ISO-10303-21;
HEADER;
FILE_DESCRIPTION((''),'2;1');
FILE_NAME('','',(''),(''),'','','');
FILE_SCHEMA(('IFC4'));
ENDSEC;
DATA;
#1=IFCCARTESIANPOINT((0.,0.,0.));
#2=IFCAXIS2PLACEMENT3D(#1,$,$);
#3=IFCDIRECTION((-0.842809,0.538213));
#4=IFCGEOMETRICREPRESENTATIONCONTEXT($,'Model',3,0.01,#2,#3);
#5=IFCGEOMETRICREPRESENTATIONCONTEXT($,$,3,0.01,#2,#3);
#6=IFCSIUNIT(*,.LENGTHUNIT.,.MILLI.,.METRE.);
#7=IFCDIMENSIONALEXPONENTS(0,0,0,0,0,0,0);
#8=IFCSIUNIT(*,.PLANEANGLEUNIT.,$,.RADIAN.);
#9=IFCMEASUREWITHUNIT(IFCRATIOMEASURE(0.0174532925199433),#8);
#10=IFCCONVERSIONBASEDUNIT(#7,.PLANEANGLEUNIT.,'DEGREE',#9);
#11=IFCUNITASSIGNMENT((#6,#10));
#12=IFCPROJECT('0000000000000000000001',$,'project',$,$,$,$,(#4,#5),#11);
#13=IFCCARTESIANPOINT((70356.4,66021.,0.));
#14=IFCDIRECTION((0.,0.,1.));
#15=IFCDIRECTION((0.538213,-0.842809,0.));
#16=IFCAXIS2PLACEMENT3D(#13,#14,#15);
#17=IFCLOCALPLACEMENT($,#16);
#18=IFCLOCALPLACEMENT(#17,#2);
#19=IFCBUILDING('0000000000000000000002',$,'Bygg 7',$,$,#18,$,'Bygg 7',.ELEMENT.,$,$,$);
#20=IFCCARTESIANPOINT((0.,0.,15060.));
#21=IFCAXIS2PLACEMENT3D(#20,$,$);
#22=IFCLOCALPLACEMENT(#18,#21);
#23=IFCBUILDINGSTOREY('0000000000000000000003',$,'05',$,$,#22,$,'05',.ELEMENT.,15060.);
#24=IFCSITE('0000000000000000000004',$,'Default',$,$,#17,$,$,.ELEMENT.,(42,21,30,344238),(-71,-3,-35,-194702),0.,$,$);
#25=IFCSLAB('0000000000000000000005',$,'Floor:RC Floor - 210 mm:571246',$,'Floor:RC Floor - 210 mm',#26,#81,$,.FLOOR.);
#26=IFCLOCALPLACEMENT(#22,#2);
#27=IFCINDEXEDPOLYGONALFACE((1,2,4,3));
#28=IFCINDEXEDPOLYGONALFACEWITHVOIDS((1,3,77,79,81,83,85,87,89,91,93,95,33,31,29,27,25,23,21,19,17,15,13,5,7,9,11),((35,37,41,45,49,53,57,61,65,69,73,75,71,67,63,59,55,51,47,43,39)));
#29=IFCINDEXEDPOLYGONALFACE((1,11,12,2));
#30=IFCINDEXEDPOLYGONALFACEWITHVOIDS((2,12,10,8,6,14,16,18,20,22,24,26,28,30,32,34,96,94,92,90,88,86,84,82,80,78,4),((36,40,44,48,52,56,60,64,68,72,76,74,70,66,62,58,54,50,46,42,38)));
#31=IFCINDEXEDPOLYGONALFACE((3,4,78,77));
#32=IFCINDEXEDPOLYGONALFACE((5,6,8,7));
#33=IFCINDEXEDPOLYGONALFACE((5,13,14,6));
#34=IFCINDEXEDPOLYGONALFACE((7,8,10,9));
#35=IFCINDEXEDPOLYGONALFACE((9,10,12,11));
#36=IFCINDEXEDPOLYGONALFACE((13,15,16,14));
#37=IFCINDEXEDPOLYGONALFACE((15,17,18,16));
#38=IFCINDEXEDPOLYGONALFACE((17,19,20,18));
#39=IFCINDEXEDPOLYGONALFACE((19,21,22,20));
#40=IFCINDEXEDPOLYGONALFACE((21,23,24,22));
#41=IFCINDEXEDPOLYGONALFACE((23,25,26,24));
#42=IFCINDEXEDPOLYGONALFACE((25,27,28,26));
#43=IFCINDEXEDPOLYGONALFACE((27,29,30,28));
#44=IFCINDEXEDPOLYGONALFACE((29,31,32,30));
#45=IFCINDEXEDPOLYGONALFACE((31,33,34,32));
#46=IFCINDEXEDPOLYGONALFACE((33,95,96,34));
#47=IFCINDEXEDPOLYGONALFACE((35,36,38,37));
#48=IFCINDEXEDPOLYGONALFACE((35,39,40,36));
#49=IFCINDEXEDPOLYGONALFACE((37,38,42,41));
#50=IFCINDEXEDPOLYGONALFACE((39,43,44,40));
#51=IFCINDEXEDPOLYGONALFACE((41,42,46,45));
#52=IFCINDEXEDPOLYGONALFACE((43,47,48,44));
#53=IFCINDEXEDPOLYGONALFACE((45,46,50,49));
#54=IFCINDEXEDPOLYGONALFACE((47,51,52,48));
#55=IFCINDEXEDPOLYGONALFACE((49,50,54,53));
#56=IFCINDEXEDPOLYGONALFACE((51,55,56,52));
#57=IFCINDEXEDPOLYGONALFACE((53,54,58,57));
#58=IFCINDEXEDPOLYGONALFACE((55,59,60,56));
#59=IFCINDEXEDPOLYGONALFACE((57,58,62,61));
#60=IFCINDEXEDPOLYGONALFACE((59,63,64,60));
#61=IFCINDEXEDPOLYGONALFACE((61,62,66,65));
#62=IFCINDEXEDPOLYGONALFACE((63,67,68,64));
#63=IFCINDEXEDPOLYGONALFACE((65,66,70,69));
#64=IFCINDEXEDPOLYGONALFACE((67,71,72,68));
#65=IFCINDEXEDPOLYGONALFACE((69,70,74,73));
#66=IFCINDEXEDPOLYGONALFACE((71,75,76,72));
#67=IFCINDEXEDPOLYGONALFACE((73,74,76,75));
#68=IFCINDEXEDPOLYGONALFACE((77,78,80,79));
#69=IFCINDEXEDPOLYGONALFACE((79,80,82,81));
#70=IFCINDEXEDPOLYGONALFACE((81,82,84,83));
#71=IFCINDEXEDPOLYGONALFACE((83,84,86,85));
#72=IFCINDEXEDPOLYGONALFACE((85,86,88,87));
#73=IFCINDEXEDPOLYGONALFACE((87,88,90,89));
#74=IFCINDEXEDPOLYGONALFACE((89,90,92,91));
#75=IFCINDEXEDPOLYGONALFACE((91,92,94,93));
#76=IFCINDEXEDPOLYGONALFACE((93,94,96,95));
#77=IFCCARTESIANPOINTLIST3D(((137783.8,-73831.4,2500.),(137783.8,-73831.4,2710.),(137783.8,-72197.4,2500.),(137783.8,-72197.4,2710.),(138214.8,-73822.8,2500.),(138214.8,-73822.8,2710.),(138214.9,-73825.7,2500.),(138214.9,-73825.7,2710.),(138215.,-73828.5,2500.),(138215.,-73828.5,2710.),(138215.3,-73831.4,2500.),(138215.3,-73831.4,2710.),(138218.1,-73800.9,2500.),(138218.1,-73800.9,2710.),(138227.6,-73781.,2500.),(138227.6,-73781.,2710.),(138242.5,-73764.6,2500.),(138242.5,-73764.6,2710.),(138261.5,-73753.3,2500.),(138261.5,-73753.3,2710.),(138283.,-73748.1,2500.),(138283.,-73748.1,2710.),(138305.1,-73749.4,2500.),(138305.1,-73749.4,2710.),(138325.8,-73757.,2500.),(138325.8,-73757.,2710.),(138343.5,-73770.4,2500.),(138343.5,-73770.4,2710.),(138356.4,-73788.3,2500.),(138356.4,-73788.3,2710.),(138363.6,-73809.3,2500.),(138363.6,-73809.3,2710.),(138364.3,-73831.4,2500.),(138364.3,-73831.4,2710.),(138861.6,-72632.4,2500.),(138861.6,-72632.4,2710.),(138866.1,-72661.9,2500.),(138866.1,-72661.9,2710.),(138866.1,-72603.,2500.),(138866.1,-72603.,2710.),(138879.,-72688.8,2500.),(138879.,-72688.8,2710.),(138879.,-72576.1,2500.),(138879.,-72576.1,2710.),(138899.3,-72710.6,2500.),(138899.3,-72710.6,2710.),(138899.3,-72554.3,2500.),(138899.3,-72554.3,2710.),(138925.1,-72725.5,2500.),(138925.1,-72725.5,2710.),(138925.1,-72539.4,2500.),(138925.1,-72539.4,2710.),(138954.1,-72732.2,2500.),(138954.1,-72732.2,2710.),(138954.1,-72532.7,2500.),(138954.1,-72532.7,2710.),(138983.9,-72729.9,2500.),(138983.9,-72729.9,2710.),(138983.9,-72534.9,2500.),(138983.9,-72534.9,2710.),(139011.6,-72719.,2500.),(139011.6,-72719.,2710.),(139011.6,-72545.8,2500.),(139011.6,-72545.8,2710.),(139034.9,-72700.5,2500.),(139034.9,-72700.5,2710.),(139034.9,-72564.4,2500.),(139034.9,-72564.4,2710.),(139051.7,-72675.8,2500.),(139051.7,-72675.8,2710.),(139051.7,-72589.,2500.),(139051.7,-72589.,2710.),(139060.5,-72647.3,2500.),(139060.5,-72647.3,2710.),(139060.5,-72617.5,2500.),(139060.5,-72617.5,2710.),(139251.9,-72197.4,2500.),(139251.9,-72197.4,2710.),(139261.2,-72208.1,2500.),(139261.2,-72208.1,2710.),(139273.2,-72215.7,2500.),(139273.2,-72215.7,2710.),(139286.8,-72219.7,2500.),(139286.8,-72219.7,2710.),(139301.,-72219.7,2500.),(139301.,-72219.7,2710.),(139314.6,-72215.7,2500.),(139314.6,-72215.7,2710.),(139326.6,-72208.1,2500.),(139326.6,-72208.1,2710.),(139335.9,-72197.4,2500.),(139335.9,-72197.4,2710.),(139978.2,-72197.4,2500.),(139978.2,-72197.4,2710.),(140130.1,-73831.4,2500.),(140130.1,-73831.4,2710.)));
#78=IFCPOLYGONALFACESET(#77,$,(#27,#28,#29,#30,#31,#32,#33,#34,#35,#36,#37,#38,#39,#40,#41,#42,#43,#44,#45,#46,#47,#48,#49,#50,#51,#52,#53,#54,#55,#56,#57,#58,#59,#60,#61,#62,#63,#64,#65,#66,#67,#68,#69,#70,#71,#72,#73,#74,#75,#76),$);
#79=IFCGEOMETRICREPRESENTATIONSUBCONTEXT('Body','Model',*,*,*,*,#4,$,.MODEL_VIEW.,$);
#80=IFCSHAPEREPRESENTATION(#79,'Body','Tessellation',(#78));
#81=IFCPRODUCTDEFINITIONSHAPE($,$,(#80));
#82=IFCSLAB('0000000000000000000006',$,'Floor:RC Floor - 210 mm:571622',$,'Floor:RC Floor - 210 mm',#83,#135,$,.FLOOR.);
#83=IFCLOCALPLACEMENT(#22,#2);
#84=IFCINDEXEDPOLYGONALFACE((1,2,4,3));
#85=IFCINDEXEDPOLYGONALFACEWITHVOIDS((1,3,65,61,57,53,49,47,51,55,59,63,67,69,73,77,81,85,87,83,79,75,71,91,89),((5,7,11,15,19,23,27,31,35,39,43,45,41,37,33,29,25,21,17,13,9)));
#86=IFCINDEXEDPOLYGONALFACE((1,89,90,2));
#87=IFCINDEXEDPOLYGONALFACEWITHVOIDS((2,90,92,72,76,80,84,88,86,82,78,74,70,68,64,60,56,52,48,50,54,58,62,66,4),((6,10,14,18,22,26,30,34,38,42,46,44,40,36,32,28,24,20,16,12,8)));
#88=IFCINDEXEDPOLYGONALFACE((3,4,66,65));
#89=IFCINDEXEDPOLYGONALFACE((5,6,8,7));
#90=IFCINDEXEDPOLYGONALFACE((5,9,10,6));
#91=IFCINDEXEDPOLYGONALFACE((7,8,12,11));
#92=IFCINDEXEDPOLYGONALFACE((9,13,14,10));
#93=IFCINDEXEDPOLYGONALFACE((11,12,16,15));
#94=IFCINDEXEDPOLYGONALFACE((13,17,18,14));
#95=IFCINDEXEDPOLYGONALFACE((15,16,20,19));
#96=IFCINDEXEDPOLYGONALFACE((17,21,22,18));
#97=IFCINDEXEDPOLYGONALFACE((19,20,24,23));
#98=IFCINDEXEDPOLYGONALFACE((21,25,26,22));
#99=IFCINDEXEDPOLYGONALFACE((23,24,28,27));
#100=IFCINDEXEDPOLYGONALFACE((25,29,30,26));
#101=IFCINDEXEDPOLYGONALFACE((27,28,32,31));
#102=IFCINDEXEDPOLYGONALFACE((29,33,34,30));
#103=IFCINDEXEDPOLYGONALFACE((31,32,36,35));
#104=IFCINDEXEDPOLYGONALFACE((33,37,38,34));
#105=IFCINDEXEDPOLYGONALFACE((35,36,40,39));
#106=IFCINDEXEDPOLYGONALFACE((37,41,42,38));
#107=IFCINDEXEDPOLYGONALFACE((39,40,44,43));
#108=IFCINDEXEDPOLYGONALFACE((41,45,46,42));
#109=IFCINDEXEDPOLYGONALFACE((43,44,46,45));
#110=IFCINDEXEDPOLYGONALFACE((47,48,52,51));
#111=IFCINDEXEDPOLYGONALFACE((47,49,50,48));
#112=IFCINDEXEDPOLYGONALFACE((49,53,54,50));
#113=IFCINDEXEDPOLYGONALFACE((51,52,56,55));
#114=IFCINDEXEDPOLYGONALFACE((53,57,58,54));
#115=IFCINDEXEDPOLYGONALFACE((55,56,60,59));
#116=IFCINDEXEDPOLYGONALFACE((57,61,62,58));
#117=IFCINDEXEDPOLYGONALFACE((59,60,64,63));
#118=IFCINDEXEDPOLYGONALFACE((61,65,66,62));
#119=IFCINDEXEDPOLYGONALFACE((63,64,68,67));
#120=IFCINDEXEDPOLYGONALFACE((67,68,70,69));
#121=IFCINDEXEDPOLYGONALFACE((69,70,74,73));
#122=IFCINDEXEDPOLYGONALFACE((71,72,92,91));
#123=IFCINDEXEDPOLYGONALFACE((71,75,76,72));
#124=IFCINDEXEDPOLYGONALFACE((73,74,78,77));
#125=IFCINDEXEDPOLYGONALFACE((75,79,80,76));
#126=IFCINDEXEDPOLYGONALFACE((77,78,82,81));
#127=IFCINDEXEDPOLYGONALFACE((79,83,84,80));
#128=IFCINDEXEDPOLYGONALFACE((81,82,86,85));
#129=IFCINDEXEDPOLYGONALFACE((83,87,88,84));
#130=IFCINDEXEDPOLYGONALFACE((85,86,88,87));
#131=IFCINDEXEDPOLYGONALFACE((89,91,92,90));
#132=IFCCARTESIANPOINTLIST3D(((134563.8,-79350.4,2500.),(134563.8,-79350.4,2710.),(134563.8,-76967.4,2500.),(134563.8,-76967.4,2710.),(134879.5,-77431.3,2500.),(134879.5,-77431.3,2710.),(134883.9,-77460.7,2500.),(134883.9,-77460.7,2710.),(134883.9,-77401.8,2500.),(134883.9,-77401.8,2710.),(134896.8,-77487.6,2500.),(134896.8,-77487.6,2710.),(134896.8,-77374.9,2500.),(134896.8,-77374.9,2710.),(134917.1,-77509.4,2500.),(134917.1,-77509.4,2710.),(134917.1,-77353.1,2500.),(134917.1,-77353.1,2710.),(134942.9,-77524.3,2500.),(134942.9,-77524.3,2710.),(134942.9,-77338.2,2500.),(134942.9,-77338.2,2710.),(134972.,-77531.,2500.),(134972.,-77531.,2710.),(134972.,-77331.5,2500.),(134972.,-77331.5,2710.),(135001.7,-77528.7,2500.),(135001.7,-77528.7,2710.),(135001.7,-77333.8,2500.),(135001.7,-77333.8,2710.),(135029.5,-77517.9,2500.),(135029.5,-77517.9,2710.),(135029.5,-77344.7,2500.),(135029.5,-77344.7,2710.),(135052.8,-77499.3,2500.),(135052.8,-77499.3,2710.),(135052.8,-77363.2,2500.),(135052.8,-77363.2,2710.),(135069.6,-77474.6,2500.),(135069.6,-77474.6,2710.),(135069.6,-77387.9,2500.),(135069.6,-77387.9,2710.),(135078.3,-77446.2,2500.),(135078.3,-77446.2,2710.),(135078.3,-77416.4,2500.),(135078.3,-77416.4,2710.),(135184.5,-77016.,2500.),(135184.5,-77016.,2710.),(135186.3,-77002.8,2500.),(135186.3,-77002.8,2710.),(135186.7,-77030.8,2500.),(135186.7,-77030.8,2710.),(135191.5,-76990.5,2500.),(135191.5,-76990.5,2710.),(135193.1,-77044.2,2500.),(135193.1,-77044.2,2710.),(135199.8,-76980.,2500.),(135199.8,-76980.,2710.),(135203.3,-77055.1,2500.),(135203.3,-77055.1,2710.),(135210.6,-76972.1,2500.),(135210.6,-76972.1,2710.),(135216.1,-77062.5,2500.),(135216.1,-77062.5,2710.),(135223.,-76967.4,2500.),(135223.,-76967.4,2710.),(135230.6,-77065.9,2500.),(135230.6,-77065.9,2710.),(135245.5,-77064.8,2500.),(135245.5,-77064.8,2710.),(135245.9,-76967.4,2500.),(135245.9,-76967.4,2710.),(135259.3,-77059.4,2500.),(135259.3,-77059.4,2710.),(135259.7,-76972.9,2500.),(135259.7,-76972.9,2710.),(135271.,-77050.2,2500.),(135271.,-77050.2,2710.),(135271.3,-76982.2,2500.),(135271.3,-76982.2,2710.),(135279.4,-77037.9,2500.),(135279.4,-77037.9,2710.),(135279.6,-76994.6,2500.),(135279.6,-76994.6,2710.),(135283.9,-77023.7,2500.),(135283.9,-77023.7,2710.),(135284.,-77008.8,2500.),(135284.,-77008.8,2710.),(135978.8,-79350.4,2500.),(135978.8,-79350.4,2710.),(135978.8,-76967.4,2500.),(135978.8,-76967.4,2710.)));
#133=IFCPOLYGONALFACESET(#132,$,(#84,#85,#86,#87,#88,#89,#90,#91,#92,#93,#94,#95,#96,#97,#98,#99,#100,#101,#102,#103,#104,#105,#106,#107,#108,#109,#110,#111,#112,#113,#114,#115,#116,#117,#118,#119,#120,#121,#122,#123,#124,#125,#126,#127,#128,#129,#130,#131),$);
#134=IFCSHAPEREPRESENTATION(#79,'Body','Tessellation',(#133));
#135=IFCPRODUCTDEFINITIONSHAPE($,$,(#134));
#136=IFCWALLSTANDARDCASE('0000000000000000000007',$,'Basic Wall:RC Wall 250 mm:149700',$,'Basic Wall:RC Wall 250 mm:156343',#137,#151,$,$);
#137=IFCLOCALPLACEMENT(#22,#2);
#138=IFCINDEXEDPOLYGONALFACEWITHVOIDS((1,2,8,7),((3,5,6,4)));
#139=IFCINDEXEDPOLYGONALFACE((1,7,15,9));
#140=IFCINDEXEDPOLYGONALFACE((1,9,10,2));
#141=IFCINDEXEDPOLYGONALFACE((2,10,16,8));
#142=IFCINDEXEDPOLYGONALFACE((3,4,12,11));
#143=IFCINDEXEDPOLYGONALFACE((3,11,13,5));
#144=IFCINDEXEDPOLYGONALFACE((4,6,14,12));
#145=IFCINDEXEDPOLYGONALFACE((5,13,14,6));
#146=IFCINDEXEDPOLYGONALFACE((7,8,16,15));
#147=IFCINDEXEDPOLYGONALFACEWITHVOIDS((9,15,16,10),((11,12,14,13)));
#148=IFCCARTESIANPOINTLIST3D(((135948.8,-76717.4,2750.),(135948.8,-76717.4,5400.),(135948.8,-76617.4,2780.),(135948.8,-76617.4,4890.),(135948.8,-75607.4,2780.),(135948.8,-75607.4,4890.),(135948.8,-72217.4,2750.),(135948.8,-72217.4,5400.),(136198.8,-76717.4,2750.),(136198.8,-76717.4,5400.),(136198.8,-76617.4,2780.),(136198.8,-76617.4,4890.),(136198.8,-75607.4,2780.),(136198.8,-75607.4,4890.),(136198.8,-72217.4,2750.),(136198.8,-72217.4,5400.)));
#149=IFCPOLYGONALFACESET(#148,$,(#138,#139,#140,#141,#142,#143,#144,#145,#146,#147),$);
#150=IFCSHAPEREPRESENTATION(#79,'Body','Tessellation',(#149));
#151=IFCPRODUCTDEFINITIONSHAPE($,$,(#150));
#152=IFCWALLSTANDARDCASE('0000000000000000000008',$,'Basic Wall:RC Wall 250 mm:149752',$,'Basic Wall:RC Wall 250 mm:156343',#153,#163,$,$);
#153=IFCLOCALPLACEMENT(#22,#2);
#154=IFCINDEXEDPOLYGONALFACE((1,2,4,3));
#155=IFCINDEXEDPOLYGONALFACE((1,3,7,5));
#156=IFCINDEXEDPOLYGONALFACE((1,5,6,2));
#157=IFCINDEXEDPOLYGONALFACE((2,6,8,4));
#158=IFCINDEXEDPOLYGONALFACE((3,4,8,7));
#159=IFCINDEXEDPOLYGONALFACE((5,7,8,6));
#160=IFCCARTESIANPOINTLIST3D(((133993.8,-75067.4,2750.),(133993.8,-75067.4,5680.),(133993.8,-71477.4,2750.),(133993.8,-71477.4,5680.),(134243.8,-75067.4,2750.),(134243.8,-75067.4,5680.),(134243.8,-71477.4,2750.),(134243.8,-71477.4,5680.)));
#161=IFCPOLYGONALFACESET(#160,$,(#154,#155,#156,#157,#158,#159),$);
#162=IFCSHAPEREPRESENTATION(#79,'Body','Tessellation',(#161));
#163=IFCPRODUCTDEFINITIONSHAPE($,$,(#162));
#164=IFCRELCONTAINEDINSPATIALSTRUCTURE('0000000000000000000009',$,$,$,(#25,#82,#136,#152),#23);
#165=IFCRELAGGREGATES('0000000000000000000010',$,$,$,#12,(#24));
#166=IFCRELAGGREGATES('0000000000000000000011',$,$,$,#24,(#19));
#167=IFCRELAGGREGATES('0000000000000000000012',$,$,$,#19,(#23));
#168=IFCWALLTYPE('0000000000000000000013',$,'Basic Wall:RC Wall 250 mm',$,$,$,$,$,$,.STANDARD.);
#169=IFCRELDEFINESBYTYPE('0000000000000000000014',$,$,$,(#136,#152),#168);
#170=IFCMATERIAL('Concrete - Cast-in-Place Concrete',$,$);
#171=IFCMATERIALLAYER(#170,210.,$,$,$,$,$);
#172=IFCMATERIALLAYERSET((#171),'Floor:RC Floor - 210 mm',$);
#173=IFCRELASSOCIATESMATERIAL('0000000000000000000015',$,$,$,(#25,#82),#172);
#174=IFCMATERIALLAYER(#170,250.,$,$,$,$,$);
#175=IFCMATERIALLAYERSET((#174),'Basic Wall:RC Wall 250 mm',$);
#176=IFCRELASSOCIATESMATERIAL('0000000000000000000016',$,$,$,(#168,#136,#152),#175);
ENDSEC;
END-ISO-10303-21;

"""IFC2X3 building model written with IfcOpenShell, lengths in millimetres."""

from ifc_helpers import new_model, entity, si_unit, converted_unit, direction, frame, frame_2d, origin, origin_2d_with_axis, place, context, subcontext, project, spatial, polyline, rectangle, circle, outline, extrude, clip, bounded_halfspace, material, layer, layer_set, layer_usage, type_object, element, save


model = new_model("IFC2X3")

# Units and contexts
model_context = context("Model", 3, precision=0.01, world=origin(), true_north=direction((-0.842809, 0.538213)))
context_of_model = context(None, 3, precision=0.01, world=origin(), true_north=direction((-0.842809, 0.538213)))
body_context = subcontext(model_context, "Body", "Model", "MODEL_VIEW")
ifc_project = project(units=[si_unit("LENGTHUNIT", "METRE", prefix="MILLI"), converted_unit("PLANEANGLEUNIT", "DEGREE", entity("IfcRatioMeasure", 0.0174532925199433), si_unit("PLANEANGLEUNIT", "RADIAN"), dimensions=[0, 0, 0, 0, 0, 0, 0])], contexts=[model_context, context_of_model])

# Site, building, storey
site_placement = place(None, frame((70356.4, 66021.0, 0.0), z_axis=(0.0, 0.0, 1.0), x_axis=(0.538213, -0.842809, 0.0)))
site = spatial("IfcSite", under=ifc_project, at=site_placement, Name="Default", CompositionType="ELEMENT", RefLatitude=(42, 21, 30, 344238), RefLongitude=(-71, -3, -35, -194702), RefElevation=0.0)
building_placement = place(site_placement, origin())
building = spatial("IfcBuilding", under=site, at=building_placement, Name="Bygg 7", LongName="Bygg 7", CompositionType="ELEMENT")
storey_placement = place(building_placement, frame((0.0, 0.0, 15060.0)))
storey = spatial("IfcBuildingStorey", under=building, at=storey_placement, Name="05", LongName="05", CompositionType="ELEMENT", Elevation=15060.0)

# Slabs, openings
ifc_material_1 = material(Name="Concrete - Cast-in-Place Concrete")
ifc_layer_1 = layer(ifc_material_1, 210.0)
ifc_layer_set_1 = layer_set([ifc_layer_1], Name="Floor:RC Floor - 210 mm")
ifc_layer_usage_1 = layer_usage(ifc_layer_set_1, "AXIS3", "POSITIVE", 0.0)
slab_1_placement = place(storey_placement, frame((137783.8, -73831.4, 2500.0)))
slab_1 = element("IfcSlab", 1, at=slab_1_placement, inside=storey, material=ifc_layer_usage_1, Name="Floor:RC Floor - 210 mm:571246", ObjectType="Floor:RC Floor - 210 mm", PredefinedType="FLOOR", context=body_context, shape_type="SweptSolid", body=[
    extrude(outline(polyline([(1173.1, 817.0), (-1021.3, 817.0), (-1173.1, -817.0), (1173.1, -817.0), (1173.1, 817.0)])), frame((1173.1, 817.0, 210.0), z_axis=(0.0, 0.0, -1.0), x_axis=(-1.0, 0.0, 0.0)), (0.0, 0.0, 1.0), 210.0),
])
opening_1_placement = place(storey_placement, frame((137783.8, -73831.4, 2500.0)))
element("IfcOpeningElement", 2, at=opening_1_placement, cuts=slab_1, ObjectType="Opening", context=body_context, shape_type="SweptSolid", body=[
    extrude(circle(Radius=100.0, at=frame_2d((-4.7, 381.9), x_axis=(1.0, 0.0))), frame((1173.1, 817.0, 210.0), z_axis=(0.0, 0.0, -1.0), x_axis=(-1.0, 0.0, 0.0)), (0.0, 0.0, 1.0), 210.0),
])
opening_2_placement = place(storey_placement, frame((137783.8, -73831.4, 2500.0)))
element("IfcOpeningElement", 3, at=opening_2_placement, cuts=slab_1, ObjectType="Opening", context=body_context, shape_type="SweptSolid", body=[
    extrude(circle(Radius=75.0, at=frame_2d((667.1, -808.4), x_axis=(1.0, 0.0))), frame((1173.1, 817.0, 210.0), z_axis=(0.0, 0.0, -1.0), x_axis=(-1.0, 0.0, 0.0)), (0.0, 0.0, 1.0), 210.0),
])
opening_3_placement = place(storey_placement, frame((137783.8, -73831.4, 2500.0)))
element("IfcOpeningElement", 4, at=opening_3_placement, cuts=slab_1, ObjectType="Opening", context=body_context, shape_type="SweptSolid", body=[
    extrude(circle(Radius=50.0, at=frame_2d((-336.9, 844.1), x_axis=(1.0, 0.0))), frame((1173.1, 817.0, 210.0), z_axis=(0.0, 0.0, -1.0), x_axis=(-1.0, 0.0, 0.0)), (0.0, 0.0, 1.0), 210.0),
])
ifc_layer_usage_2 = layer_usage(ifc_layer_set_1, "AXIS3", "POSITIVE", 0.0)
slab_2_placement = place(storey_placement, frame((134563.8, -79350.4, 2500.0)))
slab_2 = element("IfcSlab", 5, at=slab_2_placement, inside=storey, material=ifc_layer_usage_2, Name="Floor:RC Floor - 210 mm:571622", ObjectType="Floor:RC Floor - 210 mm", PredefinedType="FLOOR", context=body_context, shape_type="SweptSolid", body=[
    extrude(rectangle(XDim=2396.0, YDim=1415.0, at=frame_2d((0.0, -6.5), x_axis=(0.0, -1.0))), frame((707.5, 1191.5, 210.0), z_axis=(0.0, 0.0, -1.0), x_axis=(-1.0, 0.0, 0.0)), (0.0, 0.0, 1.0), 210.0),
])
opening_4_placement = place(storey_placement, frame((134563.8, -79350.4, 2500.0)))
element("IfcOpeningElement", 6, at=opening_4_placement, cuts=slab_2, ObjectType="Opening", context=body_context, shape_type="SweptSolid", body=[
    extrude(rectangle(XDim=1415.0, YDim=577.0, at=frame_2d((0.0, -1480.0), x_axis=(1.0, 0.0))), frame((707.5, 1191.5, 210.0), z_axis=(0.0, 0.0, -1.0), x_axis=(-1.0, 0.0, 0.0)), (0.0, 0.0, 1.0), 210.0),
])
opening_5_placement = place(storey_placement, frame((134563.8, -79350.4, 2500.0)))
element("IfcOpeningElement", 7, at=opening_5_placement, cuts=slab_2, ObjectType="Opening", context=body_context, shape_type="SweptSolid", body=[
    extrude(circle(Radius=100.0, at=frame_2d((291.9, 727.6), x_axis=(1.0, 0.0))), frame((707.5, 1191.5, 210.0), z_axis=(0.0, 0.0, -1.0), x_axis=(-1.0, 0.0, 0.0)), (0.0, 0.0, 1.0), 210.0),
])
opening_6_placement = place(storey_placement, frame((134563.8, -79350.4, 2500.0)))
element("IfcOpeningElement", 8, at=opening_6_placement, cuts=slab_2, ObjectType="Opening", context=body_context, shape_type="SweptSolid", body=[
    extrude(circle(Radius=50.0, at=frame_2d((36.9, 1142.8), x_axis=(1.0, 0.0))), frame((707.5, 1191.5, 210.0), z_axis=(0.0, 0.0, -1.0), x_axis=(-1.0, 0.0, 0.0)), (0.0, 0.0, 1.0), 210.0),
])

# Wall, opening
ifc_layer_2 = layer(ifc_material_1, 250.0)
ifc_layer_set_2 = layer_set([ifc_layer_2], Name="Basic Wall:RC Wall 250 mm")
ifc_layer_usage_3 = layer_usage(ifc_layer_set_2, "AXIS2", "NEGATIVE", 125.0)
wall_type_1 = type_object("IfcWallType", Name="Basic Wall:RC Wall 250 mm", PredefinedType="STANDARD", material=ifc_layer_set_2)
wall_1_placement = place(storey_placement, frame((136073.8, -76717.4, 2750.0), z_axis=(0.0, 0.0, 1.0), x_axis=(0.0, 1.0, 0.0)))
wall_1 = element("IfcWallStandardCase", 9, at=wall_1_placement, inside=storey, type_object=wall_type_1, material=ifc_layer_usage_3, Name="Basic Wall:RC Wall 250 mm:149700", ObjectType="Basic Wall:RC Wall 250 mm:156343", context=body_context, shape_type="Clipping", body=[
    clip(clip(extrude(rectangle(XDim=4500.0, YDim=250.0, at=frame_2d((2250.0, 0.0), x_axis=(-1.0, 0.0))), origin(), (0.0, 0.0, 1.0), 2650.0), bounded_halfspace(frame((0.0, -125.0, 2650.0), z_axis=(0.0, 0.0, -1.0), x_axis=(-0.99571, -0.092529, 0.0)), True, frame((0.0, -125.0, 2650.0)), polyline([(0.0, 0.0), (4500.0, 0.0), (4500.0, 250.0), (0.0, 250.0), (0.0, 0.0)]))), bounded_halfspace(frame((4500.0, -125.0, 0.0), z_axis=(0.0, 0.0, 1.0), x_axis=(0.99571, 0.092529, 0.0)), True, frame((4500.0, -125.0, 0.0)), polyline([(0.0, 0.0), (0.0, 250.0), (-4500.0, 250.0), (-4500.0, 0.0), (0.0, 0.0)]))),
])
opening_7_placement = place(wall_1_placement, origin())
element("IfcOpeningElement", 10, at=opening_7_placement, cuts=wall_1, ObjectType="Opening", context=body_context, shape_type="SweptSolid", body=[
    extrude(rectangle(XDim=2110.0, YDim=1010.0, at=origin_2d_with_axis()), frame((605.0, -125.0, 1085.0), z_axis=(0.0, 1.0, 0.0), x_axis=(0.0, 0.0, -1.0)), (0.0, 0.0, 1.0), 250.0),
])

# Wall
ifc_layer_usage_4 = layer_usage(ifc_layer_set_2, "AXIS2", "NEGATIVE", 125.0)
wall_2_placement = place(storey_placement, frame((134118.8, -75067.4, 2750.0), z_axis=(0.0, 0.0, 1.0), x_axis=(0.0, 1.0, 0.0)))
element("IfcWallStandardCase", 11, at=wall_2_placement, inside=storey, type_object=wall_type_1, material=ifc_layer_usage_4, Name="Basic Wall:RC Wall 250 mm:149752", ObjectType="Basic Wall:RC Wall 250 mm:156343", context=body_context, shape_type="SweptSolid", body=[
    extrude(rectangle(XDim=3590.0, YDim=250.0, at=frame_2d((1795.0, 0.0), x_axis=(-1.0, 0.0))), origin(), (0.0, 0.0, 1.0), 2930.0),
])

save(model, "model.ifc")
